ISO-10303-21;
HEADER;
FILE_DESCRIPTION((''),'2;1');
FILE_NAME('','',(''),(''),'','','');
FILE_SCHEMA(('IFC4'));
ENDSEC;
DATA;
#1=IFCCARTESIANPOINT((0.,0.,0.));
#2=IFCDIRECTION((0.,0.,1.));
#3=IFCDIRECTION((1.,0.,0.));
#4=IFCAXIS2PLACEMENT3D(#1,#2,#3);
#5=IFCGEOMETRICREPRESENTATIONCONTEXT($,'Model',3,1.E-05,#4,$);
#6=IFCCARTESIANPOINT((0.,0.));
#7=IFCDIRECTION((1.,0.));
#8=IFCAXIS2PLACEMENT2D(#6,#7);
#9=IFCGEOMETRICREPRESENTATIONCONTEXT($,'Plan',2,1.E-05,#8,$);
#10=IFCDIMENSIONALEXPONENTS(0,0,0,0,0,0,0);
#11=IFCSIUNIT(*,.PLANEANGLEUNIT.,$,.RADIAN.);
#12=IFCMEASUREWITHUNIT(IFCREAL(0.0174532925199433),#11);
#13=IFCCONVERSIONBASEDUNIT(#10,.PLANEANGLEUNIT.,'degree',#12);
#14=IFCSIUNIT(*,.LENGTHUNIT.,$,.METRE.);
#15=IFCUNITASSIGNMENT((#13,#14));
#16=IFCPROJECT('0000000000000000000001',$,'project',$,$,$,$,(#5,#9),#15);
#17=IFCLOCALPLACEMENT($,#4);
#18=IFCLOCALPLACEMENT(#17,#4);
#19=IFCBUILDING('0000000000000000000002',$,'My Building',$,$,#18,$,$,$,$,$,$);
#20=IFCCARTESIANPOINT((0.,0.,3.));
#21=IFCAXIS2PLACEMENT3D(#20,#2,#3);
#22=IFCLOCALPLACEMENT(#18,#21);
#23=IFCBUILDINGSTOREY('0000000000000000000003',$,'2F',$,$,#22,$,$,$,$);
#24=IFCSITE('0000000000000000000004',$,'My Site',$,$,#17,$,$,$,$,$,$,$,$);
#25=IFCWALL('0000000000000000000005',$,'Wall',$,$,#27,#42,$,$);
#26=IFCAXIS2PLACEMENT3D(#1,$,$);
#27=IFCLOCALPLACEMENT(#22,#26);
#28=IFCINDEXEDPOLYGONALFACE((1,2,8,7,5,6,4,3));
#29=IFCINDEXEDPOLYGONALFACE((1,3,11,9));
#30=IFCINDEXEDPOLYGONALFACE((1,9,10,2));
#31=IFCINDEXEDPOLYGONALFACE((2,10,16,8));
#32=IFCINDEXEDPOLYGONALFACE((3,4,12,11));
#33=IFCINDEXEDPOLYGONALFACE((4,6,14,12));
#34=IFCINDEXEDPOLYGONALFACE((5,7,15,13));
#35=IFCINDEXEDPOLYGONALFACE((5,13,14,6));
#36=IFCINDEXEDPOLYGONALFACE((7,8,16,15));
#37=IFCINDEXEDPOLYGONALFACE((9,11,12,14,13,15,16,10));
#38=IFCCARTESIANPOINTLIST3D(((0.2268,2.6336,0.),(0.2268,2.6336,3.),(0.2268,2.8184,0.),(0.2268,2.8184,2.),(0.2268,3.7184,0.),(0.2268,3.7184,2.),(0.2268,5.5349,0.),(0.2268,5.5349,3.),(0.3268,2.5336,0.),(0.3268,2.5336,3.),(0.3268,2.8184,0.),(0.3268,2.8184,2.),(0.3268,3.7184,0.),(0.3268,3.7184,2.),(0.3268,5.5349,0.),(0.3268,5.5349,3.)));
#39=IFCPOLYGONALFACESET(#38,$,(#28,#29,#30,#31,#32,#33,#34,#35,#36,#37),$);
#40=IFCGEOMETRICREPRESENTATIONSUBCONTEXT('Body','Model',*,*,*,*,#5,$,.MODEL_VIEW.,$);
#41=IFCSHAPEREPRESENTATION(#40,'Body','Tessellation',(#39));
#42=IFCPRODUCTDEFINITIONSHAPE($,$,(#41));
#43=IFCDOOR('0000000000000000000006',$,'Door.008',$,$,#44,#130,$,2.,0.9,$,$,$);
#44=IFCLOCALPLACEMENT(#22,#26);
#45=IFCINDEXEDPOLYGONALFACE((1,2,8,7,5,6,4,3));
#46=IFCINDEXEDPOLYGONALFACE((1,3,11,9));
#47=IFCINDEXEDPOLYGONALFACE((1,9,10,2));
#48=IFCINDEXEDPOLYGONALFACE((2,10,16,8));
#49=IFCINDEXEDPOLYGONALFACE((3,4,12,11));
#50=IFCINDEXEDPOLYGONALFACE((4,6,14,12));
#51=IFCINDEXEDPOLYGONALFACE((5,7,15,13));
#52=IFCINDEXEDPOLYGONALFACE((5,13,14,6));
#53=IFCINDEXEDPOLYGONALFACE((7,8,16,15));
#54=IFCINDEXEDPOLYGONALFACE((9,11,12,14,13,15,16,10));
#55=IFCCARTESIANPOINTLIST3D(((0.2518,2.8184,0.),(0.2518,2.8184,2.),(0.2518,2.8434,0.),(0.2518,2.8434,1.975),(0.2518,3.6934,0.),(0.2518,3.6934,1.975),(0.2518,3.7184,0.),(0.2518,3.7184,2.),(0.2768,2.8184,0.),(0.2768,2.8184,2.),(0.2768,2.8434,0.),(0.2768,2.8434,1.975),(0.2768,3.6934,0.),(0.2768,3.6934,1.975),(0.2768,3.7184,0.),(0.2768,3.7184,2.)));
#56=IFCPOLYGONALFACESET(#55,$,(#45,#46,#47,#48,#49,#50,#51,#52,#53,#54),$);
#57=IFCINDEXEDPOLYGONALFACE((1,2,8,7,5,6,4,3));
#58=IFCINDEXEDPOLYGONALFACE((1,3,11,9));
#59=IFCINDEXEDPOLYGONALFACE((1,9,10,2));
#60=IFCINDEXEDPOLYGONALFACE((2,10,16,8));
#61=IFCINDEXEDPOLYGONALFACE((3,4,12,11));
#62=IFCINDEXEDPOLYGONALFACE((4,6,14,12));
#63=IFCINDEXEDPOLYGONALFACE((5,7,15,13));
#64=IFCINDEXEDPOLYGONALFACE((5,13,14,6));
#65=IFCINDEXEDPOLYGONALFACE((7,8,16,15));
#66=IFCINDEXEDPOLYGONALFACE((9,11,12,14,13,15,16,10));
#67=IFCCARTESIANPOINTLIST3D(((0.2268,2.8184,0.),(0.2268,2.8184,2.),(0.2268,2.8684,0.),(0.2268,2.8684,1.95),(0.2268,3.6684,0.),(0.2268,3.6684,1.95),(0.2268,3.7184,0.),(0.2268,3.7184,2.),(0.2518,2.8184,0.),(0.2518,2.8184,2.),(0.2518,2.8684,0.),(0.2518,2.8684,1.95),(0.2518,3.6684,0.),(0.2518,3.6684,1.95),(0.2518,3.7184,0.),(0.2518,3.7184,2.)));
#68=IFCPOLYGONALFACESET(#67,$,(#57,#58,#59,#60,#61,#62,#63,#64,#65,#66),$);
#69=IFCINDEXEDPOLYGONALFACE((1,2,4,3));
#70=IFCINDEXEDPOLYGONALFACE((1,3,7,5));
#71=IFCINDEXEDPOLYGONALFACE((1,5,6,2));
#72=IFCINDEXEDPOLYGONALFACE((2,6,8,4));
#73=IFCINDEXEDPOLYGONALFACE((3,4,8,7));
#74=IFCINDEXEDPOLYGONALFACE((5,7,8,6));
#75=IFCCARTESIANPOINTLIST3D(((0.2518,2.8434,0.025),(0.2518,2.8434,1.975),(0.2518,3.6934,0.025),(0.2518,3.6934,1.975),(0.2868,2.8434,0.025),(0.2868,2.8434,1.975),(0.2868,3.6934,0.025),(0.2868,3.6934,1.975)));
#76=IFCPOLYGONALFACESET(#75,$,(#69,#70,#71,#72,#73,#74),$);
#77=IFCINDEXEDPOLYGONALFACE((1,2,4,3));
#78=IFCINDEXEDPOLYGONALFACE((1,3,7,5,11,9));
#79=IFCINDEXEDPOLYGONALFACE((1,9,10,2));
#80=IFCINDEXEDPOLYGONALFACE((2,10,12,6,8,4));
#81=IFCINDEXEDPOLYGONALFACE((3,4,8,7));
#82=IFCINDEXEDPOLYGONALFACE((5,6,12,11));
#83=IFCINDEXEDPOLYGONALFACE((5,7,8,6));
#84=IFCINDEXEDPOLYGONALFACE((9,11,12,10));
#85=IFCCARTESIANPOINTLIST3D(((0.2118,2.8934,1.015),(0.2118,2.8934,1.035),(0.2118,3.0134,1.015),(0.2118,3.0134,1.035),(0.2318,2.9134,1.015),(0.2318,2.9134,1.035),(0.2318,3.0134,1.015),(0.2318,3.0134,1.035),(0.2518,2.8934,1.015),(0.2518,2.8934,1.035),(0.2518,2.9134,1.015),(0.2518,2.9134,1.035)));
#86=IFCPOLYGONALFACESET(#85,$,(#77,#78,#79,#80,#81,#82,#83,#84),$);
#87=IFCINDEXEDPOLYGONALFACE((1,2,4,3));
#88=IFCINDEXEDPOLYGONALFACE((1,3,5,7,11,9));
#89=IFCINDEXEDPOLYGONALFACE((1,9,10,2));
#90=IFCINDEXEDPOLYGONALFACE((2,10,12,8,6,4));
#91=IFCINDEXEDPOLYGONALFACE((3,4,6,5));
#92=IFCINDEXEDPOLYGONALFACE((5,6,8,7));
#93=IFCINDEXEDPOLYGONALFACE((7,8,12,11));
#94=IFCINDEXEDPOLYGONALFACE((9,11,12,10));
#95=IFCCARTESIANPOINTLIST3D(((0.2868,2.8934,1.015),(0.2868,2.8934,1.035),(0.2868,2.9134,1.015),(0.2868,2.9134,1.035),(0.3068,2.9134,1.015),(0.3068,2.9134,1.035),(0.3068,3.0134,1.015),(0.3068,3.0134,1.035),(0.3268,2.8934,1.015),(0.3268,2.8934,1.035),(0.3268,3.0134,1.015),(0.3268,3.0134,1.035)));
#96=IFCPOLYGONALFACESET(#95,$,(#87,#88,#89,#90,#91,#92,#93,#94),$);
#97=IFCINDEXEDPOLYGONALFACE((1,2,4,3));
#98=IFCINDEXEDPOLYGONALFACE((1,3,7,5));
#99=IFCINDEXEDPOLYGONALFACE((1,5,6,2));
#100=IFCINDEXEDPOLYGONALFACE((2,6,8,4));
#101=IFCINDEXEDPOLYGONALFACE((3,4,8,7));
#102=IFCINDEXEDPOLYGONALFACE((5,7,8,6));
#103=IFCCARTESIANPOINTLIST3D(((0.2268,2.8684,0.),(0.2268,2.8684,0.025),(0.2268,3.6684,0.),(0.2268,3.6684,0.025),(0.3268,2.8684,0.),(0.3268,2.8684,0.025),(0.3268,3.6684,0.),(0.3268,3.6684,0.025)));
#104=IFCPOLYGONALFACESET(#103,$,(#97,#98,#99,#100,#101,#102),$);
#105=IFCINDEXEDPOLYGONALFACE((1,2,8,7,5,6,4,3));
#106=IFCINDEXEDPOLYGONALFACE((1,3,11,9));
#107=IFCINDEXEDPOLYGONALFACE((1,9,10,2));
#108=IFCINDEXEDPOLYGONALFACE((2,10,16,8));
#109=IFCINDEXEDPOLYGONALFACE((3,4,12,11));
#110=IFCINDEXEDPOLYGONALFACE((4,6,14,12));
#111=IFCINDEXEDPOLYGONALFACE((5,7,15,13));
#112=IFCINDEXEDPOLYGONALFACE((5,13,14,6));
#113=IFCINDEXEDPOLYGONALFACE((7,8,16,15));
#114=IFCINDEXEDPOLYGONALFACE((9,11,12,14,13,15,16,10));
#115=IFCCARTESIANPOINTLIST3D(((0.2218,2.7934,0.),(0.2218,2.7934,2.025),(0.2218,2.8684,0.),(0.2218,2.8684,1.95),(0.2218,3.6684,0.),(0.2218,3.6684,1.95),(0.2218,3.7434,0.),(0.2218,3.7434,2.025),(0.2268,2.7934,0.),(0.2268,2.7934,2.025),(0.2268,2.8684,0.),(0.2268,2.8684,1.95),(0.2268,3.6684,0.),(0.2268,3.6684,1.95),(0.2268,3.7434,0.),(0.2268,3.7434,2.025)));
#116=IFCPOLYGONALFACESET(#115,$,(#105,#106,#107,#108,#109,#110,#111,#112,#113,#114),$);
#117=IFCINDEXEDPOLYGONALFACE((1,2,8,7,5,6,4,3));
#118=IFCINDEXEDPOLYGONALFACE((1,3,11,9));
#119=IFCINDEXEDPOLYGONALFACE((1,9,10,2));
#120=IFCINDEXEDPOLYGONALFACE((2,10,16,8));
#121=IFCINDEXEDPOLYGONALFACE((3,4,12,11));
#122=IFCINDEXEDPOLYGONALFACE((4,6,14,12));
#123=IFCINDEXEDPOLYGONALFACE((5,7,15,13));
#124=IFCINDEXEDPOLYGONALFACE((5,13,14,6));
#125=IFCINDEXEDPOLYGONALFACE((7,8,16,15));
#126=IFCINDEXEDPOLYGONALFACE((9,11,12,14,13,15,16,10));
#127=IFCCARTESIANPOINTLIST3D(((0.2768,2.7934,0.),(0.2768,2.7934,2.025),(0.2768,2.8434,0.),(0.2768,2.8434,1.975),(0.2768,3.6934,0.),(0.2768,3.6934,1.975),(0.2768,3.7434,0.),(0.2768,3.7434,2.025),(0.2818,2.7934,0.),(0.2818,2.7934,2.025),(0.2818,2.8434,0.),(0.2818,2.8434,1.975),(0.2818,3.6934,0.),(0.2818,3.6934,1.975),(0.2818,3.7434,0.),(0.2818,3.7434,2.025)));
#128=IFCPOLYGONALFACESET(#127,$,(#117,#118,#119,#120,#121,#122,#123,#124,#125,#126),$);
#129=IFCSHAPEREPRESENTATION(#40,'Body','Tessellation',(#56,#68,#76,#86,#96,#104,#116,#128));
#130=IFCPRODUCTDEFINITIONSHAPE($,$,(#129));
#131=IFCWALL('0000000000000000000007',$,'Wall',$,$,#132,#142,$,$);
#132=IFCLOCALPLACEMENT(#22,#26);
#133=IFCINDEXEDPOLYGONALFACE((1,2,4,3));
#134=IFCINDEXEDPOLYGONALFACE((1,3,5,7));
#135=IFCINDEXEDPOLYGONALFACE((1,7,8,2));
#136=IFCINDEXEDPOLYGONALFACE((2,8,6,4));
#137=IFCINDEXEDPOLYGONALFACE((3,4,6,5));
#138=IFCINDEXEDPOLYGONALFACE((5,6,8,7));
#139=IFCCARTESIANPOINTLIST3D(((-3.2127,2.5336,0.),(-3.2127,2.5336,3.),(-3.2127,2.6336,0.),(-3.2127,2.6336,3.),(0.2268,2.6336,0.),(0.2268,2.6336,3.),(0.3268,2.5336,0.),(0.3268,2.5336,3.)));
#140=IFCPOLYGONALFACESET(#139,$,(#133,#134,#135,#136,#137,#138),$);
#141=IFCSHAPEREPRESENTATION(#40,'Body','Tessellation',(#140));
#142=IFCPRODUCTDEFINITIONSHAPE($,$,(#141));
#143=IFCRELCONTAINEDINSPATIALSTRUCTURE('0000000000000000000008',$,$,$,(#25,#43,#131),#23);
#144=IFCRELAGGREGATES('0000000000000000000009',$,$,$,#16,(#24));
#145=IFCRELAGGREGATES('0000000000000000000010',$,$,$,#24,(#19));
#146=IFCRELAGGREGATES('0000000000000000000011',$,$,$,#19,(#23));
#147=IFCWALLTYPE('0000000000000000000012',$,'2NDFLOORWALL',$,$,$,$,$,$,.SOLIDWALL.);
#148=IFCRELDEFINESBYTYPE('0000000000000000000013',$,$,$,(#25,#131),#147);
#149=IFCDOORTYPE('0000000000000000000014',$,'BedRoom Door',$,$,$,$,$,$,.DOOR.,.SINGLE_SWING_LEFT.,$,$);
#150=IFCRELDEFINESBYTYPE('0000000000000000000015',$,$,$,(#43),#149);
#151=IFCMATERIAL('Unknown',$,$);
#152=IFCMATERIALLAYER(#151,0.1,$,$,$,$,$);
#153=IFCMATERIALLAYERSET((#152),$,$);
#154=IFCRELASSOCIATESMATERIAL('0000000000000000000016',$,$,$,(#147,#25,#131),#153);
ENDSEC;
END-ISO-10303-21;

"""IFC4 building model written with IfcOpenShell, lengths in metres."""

from ifc_helpers import new_model, entity, si_unit, converted_unit, frame, origin_with_axes, origin_2d_with_axis, place, context, subcontext, project, spatial, line, indexed_curve, outline, extrude, shape, source, transform, mapped, material, layer, layer_set, layer_usage, type_object, type_shapes, element, fill, save


model = new_model("IFC4")

# Units and contexts
model_context = context("Model", 3, precision=1e-05, world=origin_with_axes())
plan_context = context("Plan", 2, precision=1e-05, world=origin_2d_with_axis())
body_context_1 = subcontext(model_context, "Body", "Model", "MODEL_VIEW")
body_context_2 = subcontext(plan_context, "Body", "Plan", "PLAN_VIEW")
ifc_project = project(units=[converted_unit("PLANEANGLEUNIT", "degree", entity("IfcReal", 0.0174532925199433), si_unit("PLANEANGLEUNIT", "RADIAN"), dimensions=[0, 0, 0, 0, 0, 0, 0]), si_unit("LENGTHUNIT", "METRE")], contexts=[model_context, plan_context])

# Site, building, storey
site_placement = place(None, origin_with_axes())
site = spatial("IfcSite", under=ifc_project, at=site_placement, Name="My Site")
building_placement = place(site_placement, origin_with_axes())
building = spatial("IfcBuilding", under=site, at=building_placement, Name="My Building")
storey_placement = place(building_placement, frame((0.0, 0.0, 3.0), z_axis=(0.0, 0.0, 1.0), x_axis=(1.0, 0.0, 0.0)))
storey = spatial("IfcBuildingStorey", under=building, at=storey_placement, Name="2F")

# Shared definitions
ifc_material = material(Name="Unknown")

# Shared definitions
ifc_layer_1 = layer(ifc_material, 0.1)
ifc_layer_set_1 = layer_set([ifc_layer_1])
wall_type_1 = type_object("IfcWallType", Name="2NDFLOORWALL", PredefinedType="SOLIDWALL", material=ifc_layer_set_1)

# Wall, opening, door
ifc_layer_usage_1 = layer_usage(ifc_layer_set_1, "AXIS2", "POSITIVE", 0.0)
wall_1_placement = place(storey_placement, frame((0.2268, 5.5349, 0.0), z_axis=(0.0, 0.0, 1.0), x_axis=(0.0, -1.0, 0.0)))
wall_1 = element("IfcWall", 1, at=wall_1_placement, inside=storey, type_object=wall_type_1, material=ifc_layer_usage_1, Name="Wall", context=body_context_1, shape_type="SweptSolid", body=[
    extrude(outline(indexed_curve([(0.0, 0.0), (0.0, 0.1), (3.0013, 0.1), (2.9013, 0.0)], segments=[line(1, 2, 3, 4, 1)])), origin_with_axes(), (0.0, 0.0, 1.0), 3.0),
])
shared_shape_1 = source(origin_with_axes(), body_context_1, "Body", "SweptSolid", [
    extrude(outline(indexed_curve([(0.0, 0.0), (0.9, 0.0), (0.9, 2.0), (0.0, 2.0)], segments=[line(1, 2, 3, 4, 1)])), frame((0.0, -0.6, 0.0), z_axis=(0.0, -1.0, 0.0), x_axis=(1.0, 0.0, 0.0)), (0.0, 0.0, -1.0), 1.2),
])
opening_1_placement = place(wall_1_placement, frame((1.8165, 0.0, 0.0), z_axis=(0.0, 0.0, 1.0), x_axis=(1.0, 0.0, 0.0)))
opening_1 = element("IfcOpeningElement", 2, at=opening_1_placement, cuts=wall_1, PredefinedType="OPENING", context=body_context_1, shape_type="MappedRepresentation", body=[
    mapped(shared_shape_1, transform((0.0, 0.0, 0.0), x_axis=(1.0, 0.0, 0.0), y_axis=(0.0, 1.0, 0.0), z_axis=(0.0, 0.0, 1.0), scale=1.0)),
])
door_type_1 = type_object("IfcDoorType", Name="BedRoom Door", OperationType="SINGLE_SWING_LEFT", PredefinedType="DOOR")
shared_shape_2 = source(origin_with_axes(), body_context_1, "Body", "SweptSolid", [
    extrude(outline(indexed_curve([(0.0, 0.0), (0.0, 2.0), (0.9, 2.0), (0.9, 0.0), (0.875, 0.0), (0.875, 1.975), (0.025, 1.975), (0.025, 0.0)], segments=[line(1, 2, 3, 4, 5, 6, 7, 8, 1)])), frame((0.0, 0.025, 0.0), z_axis=(0.0, -1.0, 0.0), x_axis=(1.0, 0.0, 0.0)), (0.0, 0.0, -1.0), 0.025),
    extrude(outline(indexed_curve([(0.0, 0.0), (0.0, 2.0), (0.9, 2.0), (0.9, 0.0), (0.85, 0.0), (0.85, 1.95), (0.05, 1.95), (0.05, 0.0)], segments=[line(1, 2, 3, 4, 5, 6, 7, 8, 1)])), frame((0.0, 0.0, 0.0), z_axis=(0.0, -1.0, 0.0), x_axis=(1.0, 0.0, 0.0)), (0.0, 0.0, -1.0), 0.025),
    extrude(outline(indexed_curve([(0.0, 0.0), (0.85, 0.0), (0.85, 0.035), (0.0, 0.035)], segments=[line(1, 2, 3, 4, 1)])), frame((0.025, 0.025, 0.025), z_axis=(0.0, 0.0, 1.0), x_axis=(1.0, 0.0, 0.0)), (0.0, 0.0, 1.0), 1.95),
    extrude(outline(indexed_curve([(0.0, 0.0), (0.0, -0.04), (-0.12, -0.04), (-0.12, -0.02), (-0.02, -0.02), (-0.02, 0.0)], segments=[line(1, 2, 3, 4, 5, 6, 1)])), frame((0.825, 0.025, 1.015), z_axis=(0.0, 0.0, 1.0), x_axis=(1.0, 0.0, 0.0)), (0.0, 0.0, 1.0), 0.02),
    extrude(outline(indexed_curve([(0.0, 0.0), (0.0, 0.04), (-0.12, 0.04), (-0.12, 0.02), (-0.02, 0.02), (-0.02, 0.0)], segments=[line(1, 2, 3, 4, 5, 6, 1)])), frame((0.825, 0.06, 1.015), z_axis=(0.0, 0.0, 1.0), x_axis=(1.0, 0.0, 0.0)), (0.0, 0.0, 1.0), 0.02),
    extrude(outline(indexed_curve([(0.0, 0.0), (0.8, 0.0), (0.8, 0.1), (0.0, 0.1)], segments=[line(1, 2, 3, 4, 1)])), frame((0.05, 0.0, 0.0), z_axis=(0.0, 0.0, 1.0), x_axis=(1.0, 0.0, 0.0)), (0.0, 0.0, 1.0), 0.025),
    extrude(outline(indexed_curve([(0.0, 0.0), (0.0, 2.025), (0.95, 2.025), (0.95, 0.0), (0.875, 0.0), (0.875, 1.95), (0.075, 1.95), (0.075, 0.0)], segments=[line(1, 2, 3, 4, 5, 6, 7, 8, 1)])), frame((-0.025, -0.005, 0.0), z_axis=(0.0, -1.0, 0.0), x_axis=(1.0, 0.0, 0.0)), (0.0, 0.0, -1.0), 0.005),
    extrude(outline(indexed_curve([(0.0, 0.0), (0.0, 2.025), (0.95, 2.025), (0.95, 0.0), (0.9, 0.0), (0.9, 1.975), (0.05, 1.975), (0.05, 0.0)], segments=[line(1, 2, 3, 4, 5, 6, 7, 8, 1)])), frame((-0.025, 0.05, 0.0), z_axis=(0.0, -1.0, 0.0), x_axis=(1.0, 0.0, 0.0)), (0.0, 0.0, -1.0), 0.005),
])
shared_shape_3 = source(origin_with_axes(), body_context_2, "Body", "Curve2D", [
    entity("IfcIndexedPolyCurve", entity("IfcCartesianPointList2D", [[0.0, 0.0], [0.0, 0.05], [0.025, 0.05], [0.025, 0.025], [0.05, 0.025], [0.05, 0.0]]), [entity("IfcLineIndex", [1, 2, 3, 4, 5, 6, 1])]),
    entity("IfcIndexedPolyCurve", entity("IfcCartesianPointList2D", [[0.9, 0.0], [0.9, 0.05], [0.875, 0.05], [0.875, 0.025], [0.85, 0.025], [0.85, 0.0]]), [entity("IfcLineIndex", [1, 2, 3, 4, 5, 6, 1])]),
    entity("IfcTrimmedCurve", entity("IfcEllipse", entity("IfcAxis2Placement2D", entity("IfcCartesianPoint", [0.06, 0.05]), entity("IfcDirection", [1.0, 0.0])), 0.815, 0.85), [entity("IfcCartesianPoint", [0.875, 0.05])], [entity("IfcCartesianPoint", [0.06, 0.9])], True, "CARTESIAN"),
    entity("IfcIndexedPolyCurve", entity("IfcCartesianPointList2D", [[0.025, 0.05], [0.06, 0.05], [0.06, 0.9], [0.025, 0.9]]), [entity("IfcLineIndex", [1, 2, 3, 4, 1])]),
])
type_shapes(door_type_1, [shared_shape_2, shared_shape_3])
door_1_placement = place(opening_1_placement, frame((0.0, 0.0, 0.0), z_axis=(0.0, 0.0, 1.0), x_axis=(1.0, 0.0, 0.0)))
door_1 = element("IfcDoor", 3, at=door_1_placement, inside=storey, type_object=door_type_1, Name="Door.008", OverallHeight=2.0, OverallWidth=0.9, shapes=[
    shape(body_context_1, "Body", "MappedRepresentation", [mapped(shared_shape_2, transform((0.0, 0.0, 0.0), x_axis=(1.0, 0.0, 0.0), y_axis=(0.0, 1.0, 0.0), z_axis=(0.0, 0.0, 1.0), scale=1.0))]),
    shape(body_context_2, "Body", "MappedRepresentation", [mapped(shared_shape_3, transform((0.0, 0.0, 0.0), x_axis=(1.0, 0.0, 0.0), y_axis=(0.0, 1.0, 0.0), z_axis=(0.0, 0.0, 1.0), scale=1.0))]),
])
fill(opening_1, door_1)

# Wall
ifc_layer_usage_2 = layer_usage(ifc_layer_set_1, "AXIS2", "POSITIVE", 0.0)
wall_2_placement = place(storey_placement, frame((0.2268, 2.6336, 0.0), z_axis=(0.0, 0.0, 1.0), x_axis=(-1.0, 0.0, 0.0)))
element("IfcWall", 4, at=wall_2_placement, inside=storey, type_object=wall_type_1, material=ifc_layer_usage_2, Name="Wall", context=body_context_1, shape_type="SweptSolid", body=[
    extrude(outline(indexed_curve([(0.0, 0.0), (-0.1, 0.1), (3.4395, 0.1), (3.4395, 0.0)], segments=[line(1, 2, 3, 4, 1)])), origin_with_axes(), (0.0, 0.0, 1.0), 3.0),
])

save(model, "model.ifc")
